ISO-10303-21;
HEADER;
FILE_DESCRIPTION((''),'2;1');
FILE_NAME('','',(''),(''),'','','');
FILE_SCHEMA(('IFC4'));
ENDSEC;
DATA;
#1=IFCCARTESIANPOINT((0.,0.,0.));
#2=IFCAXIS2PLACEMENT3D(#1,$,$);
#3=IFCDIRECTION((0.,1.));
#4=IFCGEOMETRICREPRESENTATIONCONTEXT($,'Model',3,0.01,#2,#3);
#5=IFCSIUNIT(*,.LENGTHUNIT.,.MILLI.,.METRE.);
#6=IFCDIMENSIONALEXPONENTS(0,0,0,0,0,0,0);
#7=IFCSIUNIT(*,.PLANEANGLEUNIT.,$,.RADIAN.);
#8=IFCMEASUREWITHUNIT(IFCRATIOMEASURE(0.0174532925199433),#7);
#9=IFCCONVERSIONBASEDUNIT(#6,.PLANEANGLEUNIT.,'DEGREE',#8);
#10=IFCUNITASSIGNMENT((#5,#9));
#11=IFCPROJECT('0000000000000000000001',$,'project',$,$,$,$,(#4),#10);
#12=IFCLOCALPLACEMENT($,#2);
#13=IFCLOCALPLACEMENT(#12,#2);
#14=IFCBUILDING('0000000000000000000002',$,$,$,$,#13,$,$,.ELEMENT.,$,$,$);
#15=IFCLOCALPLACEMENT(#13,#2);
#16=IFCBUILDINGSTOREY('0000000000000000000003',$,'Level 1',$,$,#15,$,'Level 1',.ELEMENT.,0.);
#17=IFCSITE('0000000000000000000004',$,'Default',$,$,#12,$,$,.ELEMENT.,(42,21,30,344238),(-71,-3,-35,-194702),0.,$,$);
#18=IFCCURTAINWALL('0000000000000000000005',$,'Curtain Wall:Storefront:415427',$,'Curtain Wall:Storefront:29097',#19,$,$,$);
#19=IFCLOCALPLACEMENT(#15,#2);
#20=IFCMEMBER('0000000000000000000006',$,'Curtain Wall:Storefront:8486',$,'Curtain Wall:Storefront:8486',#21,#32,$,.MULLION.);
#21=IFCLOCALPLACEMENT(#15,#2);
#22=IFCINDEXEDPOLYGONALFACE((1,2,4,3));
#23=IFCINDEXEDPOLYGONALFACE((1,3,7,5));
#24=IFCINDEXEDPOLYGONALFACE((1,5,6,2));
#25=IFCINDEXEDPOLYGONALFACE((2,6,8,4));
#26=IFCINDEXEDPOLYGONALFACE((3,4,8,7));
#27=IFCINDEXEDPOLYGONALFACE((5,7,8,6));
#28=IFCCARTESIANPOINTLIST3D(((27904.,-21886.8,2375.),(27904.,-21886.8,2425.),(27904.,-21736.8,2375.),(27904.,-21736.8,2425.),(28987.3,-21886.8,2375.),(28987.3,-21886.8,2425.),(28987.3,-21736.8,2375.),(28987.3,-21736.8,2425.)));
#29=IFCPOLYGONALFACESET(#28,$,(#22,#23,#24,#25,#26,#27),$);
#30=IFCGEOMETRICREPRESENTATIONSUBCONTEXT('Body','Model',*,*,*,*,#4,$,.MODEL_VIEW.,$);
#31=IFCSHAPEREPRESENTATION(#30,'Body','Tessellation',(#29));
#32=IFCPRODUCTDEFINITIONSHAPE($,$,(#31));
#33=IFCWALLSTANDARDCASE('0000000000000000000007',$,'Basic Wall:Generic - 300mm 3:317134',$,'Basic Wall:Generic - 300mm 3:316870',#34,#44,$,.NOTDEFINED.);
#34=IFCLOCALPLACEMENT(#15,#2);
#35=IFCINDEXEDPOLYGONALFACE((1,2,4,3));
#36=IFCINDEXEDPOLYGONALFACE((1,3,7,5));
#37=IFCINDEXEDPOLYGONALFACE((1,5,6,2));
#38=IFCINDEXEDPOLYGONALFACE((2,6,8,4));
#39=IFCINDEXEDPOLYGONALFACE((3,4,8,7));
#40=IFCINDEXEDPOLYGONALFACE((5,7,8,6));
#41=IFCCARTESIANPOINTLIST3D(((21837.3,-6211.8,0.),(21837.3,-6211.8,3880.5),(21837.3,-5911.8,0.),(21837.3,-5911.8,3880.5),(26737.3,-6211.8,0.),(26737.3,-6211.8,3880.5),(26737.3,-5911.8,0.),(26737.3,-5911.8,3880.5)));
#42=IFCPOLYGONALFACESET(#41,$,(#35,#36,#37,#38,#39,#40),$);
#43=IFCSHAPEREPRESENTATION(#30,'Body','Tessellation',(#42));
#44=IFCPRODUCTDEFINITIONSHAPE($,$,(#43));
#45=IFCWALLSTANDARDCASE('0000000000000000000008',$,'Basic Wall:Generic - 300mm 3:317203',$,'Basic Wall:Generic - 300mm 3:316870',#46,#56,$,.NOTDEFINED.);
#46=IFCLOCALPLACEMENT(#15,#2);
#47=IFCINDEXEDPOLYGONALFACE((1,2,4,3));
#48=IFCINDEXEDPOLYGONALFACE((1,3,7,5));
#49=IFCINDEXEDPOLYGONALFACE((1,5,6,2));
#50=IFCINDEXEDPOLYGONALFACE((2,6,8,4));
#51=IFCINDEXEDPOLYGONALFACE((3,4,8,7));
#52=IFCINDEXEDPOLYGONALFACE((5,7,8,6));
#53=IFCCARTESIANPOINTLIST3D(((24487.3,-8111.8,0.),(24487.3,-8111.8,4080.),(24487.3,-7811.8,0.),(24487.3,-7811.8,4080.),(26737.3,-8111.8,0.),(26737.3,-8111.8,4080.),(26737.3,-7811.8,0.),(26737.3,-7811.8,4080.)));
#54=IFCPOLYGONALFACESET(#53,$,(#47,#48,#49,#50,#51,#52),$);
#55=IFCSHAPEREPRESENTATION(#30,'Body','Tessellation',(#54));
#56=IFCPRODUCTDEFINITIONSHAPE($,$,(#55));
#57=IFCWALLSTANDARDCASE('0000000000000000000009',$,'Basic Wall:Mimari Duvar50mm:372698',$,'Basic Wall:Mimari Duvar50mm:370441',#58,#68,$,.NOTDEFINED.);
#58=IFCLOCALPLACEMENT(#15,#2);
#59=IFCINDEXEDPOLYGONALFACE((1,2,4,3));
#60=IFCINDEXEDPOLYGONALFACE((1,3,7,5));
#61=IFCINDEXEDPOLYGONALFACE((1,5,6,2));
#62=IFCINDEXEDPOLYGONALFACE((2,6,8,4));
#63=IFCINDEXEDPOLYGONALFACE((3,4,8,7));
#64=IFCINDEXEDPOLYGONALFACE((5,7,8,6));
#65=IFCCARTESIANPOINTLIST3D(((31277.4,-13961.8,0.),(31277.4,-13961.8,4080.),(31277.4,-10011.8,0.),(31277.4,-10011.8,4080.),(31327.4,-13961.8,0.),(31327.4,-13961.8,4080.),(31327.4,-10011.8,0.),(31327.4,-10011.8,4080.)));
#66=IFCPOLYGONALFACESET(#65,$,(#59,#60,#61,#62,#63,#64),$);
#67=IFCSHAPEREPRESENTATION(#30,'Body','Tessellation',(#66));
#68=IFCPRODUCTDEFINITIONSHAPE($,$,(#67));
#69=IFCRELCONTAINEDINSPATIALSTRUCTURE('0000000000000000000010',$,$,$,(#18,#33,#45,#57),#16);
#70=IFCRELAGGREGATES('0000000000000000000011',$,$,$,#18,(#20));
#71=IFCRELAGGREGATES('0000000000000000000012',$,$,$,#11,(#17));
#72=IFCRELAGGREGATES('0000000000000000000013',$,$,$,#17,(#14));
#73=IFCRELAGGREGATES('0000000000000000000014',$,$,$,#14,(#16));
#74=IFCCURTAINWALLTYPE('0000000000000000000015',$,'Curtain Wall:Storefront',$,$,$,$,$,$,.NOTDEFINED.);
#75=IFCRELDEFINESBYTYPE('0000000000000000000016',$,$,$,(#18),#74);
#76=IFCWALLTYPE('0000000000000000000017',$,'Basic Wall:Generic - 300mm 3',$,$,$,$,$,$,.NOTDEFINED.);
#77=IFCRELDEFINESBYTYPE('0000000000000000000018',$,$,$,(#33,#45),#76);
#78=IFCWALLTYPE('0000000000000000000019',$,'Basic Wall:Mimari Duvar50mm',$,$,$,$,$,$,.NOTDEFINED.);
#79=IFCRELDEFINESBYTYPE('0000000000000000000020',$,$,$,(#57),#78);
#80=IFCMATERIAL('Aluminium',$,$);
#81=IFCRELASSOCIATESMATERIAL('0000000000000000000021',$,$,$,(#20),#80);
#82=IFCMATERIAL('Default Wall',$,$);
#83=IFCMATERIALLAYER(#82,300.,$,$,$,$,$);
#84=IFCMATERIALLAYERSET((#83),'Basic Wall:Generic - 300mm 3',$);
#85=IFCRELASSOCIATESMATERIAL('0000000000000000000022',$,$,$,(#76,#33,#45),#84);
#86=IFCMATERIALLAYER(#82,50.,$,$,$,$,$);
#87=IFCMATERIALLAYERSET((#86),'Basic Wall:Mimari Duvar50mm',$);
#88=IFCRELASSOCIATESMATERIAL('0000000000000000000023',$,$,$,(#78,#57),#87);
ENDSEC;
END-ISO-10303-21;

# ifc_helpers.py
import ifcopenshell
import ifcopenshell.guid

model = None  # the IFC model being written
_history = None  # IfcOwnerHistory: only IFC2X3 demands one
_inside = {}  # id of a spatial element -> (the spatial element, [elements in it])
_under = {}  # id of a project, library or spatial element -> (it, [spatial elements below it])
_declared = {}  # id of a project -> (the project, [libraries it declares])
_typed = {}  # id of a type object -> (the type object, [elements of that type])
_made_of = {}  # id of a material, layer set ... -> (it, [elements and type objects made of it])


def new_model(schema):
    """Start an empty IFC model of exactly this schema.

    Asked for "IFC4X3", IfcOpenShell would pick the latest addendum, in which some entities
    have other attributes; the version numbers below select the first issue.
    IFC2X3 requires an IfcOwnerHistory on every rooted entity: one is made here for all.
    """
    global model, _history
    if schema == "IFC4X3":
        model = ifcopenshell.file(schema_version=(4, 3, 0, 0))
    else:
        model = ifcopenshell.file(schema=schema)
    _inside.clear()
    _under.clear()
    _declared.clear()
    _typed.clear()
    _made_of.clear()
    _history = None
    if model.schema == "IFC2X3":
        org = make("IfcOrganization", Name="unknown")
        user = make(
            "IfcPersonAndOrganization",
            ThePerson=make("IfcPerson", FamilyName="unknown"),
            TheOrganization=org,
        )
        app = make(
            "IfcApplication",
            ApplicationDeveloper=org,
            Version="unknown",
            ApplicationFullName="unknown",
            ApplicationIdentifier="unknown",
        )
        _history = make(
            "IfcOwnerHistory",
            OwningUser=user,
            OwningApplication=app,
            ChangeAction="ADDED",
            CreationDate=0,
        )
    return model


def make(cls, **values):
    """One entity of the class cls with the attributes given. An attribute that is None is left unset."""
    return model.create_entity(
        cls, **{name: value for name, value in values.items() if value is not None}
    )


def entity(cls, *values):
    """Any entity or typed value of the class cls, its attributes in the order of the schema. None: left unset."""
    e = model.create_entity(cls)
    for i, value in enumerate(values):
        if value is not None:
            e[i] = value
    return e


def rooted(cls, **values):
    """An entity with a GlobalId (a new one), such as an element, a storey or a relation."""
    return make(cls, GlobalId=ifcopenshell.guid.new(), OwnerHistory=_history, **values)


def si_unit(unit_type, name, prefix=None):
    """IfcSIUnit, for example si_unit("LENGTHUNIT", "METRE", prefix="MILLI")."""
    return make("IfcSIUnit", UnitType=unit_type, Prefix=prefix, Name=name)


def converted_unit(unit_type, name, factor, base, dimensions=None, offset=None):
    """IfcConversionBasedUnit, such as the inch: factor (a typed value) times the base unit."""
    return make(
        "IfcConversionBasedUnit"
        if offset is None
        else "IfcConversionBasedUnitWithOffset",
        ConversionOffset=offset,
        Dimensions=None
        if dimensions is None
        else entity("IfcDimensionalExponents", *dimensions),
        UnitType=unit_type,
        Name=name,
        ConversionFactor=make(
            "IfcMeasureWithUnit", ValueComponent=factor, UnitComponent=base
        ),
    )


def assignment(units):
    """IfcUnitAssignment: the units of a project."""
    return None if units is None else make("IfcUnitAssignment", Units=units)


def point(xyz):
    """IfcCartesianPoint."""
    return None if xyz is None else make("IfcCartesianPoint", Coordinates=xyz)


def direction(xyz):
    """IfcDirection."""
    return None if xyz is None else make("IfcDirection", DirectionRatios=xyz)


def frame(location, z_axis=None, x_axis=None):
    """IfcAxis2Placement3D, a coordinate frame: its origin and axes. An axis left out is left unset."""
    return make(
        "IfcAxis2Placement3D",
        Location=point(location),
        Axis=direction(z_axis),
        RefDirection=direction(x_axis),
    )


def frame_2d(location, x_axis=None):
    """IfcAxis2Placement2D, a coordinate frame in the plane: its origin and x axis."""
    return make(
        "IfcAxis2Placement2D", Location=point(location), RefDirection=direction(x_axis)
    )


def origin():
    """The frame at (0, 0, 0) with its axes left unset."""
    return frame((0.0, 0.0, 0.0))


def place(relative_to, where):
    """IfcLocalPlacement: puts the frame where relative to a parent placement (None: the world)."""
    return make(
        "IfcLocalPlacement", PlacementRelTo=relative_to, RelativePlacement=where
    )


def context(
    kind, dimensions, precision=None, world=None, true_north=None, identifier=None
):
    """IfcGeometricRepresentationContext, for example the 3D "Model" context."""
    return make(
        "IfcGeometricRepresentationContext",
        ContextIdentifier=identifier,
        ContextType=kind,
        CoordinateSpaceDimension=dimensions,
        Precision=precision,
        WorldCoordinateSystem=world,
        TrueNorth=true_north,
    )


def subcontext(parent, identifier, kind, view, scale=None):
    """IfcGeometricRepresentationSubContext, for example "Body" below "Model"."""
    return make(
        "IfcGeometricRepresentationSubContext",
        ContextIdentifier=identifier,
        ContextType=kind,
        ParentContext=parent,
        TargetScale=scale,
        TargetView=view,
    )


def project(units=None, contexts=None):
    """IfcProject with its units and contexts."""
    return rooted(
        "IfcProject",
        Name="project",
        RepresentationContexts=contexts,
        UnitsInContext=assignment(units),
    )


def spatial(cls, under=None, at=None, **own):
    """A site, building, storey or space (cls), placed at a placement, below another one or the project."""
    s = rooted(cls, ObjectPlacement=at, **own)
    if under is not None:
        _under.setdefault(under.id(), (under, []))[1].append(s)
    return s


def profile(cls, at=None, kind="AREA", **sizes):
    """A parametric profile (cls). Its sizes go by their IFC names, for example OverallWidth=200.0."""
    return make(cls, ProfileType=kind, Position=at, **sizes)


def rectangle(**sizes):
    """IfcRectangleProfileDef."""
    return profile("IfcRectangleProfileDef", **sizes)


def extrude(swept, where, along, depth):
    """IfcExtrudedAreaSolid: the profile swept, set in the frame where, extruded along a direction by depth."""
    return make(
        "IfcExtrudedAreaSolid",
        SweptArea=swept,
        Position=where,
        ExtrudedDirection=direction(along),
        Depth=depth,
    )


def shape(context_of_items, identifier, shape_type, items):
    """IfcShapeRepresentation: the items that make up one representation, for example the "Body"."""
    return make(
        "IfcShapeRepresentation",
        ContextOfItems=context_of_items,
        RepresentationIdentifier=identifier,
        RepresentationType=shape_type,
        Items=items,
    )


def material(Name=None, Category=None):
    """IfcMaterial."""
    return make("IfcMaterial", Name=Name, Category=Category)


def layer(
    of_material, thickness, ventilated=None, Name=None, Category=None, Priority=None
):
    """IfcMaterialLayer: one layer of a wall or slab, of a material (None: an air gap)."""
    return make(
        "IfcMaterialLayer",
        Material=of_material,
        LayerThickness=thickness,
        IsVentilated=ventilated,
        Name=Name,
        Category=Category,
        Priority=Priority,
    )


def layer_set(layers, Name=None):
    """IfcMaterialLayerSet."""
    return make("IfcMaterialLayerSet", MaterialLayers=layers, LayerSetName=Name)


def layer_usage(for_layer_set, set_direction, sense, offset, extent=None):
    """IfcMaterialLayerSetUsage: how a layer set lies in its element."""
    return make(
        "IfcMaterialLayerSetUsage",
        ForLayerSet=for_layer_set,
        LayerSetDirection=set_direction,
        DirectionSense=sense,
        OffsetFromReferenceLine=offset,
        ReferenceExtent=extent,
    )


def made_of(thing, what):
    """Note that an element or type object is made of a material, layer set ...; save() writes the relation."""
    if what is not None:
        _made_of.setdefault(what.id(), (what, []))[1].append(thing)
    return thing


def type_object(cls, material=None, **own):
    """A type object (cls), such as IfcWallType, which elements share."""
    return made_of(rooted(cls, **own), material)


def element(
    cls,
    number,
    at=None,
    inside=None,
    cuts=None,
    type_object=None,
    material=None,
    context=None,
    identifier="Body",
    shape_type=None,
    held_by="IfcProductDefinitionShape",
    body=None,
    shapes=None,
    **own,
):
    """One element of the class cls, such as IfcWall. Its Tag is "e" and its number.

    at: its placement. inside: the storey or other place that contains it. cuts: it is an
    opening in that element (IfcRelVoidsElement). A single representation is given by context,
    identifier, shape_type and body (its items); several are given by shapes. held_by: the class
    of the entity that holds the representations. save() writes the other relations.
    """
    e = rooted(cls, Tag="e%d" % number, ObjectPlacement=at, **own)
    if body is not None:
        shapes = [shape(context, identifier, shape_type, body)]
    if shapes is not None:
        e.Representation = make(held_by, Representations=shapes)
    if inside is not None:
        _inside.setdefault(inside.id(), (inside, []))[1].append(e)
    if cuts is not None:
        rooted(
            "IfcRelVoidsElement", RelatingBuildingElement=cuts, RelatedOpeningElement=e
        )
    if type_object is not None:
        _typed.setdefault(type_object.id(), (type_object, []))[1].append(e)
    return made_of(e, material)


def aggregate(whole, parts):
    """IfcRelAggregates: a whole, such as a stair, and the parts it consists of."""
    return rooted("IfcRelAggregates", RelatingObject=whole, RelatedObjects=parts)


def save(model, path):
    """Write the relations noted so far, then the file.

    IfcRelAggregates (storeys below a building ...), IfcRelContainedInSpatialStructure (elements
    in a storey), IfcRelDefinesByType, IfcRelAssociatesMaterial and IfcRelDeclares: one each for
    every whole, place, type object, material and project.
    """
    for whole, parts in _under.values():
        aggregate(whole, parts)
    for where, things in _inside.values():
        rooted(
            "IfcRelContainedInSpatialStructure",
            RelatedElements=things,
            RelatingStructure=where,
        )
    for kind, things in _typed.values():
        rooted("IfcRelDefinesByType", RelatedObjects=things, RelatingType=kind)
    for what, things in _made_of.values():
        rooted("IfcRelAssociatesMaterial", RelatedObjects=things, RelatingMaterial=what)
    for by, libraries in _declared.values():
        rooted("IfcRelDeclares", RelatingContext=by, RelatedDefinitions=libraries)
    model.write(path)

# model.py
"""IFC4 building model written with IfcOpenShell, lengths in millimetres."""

from ifc_helpers import new_model, entity, si_unit, converted_unit, direction, frame, frame_2d, origin, place, context, subcontext, project, spatial, rectangle, extrude, material, layer, layer_set, layer_usage, type_object, element, aggregate, save


model = new_model("IFC4")

# Units and contexts
model_context = context("Model", 3, precision=0.01, world=origin(), true_north=direction((0.0, 1.0)))
body_context = subcontext(model_context, "Body", "Model", "MODEL_VIEW")
ifc_project = project(units=[si_unit("LENGTHUNIT", "METRE", prefix="MILLI"), converted_unit("PLANEANGLEUNIT", "DEGREE", entity("IfcRatioMeasure", 0.0174532925199433), si_unit("PLANEANGLEUNIT", "RADIAN"), dimensions=[0, 0, 0, 0, 0, 0, 0])], contexts=[model_context])

# Site, building, storey
site_placement = place(None, origin())
site = spatial("IfcSite", under=ifc_project, at=site_placement, Name="Default", CompositionType="ELEMENT", RefLatitude=(42, 21, 30, 344238), RefLongitude=(-71, -3, -35, -194702), RefElevation=0.0)
building_placement = place(site_placement, origin())
building = spatial("IfcBuilding", under=site, at=building_placement, CompositionType="ELEMENT")
storey_placement = place(building_placement, origin())
storey = spatial("IfcBuildingStorey", under=building, at=storey_placement, Name="Level 1", LongName="Level 1", CompositionType="ELEMENT", Elevation=0.0)

# Curtain wall, member
curtain_wall_type = type_object("IfcCurtainWallType", Name="Curtain Wall:Storefront", PredefinedType="NOTDEFINED")
ifc_material_1 = material(Name="Aluminium")
curtain_wall_1_placement = place(storey_placement, origin())
curtain_wall_1 = element("IfcCurtainWall", 1, at=curtain_wall_1_placement, inside=storey, type_object=curtain_wall_type, Name="Curtain Wall:Storefront:415427", ObjectType="Curtain Wall:Storefront:29097")
member_1_placement = place(curtain_wall_1_placement, origin())
member_1 = element("IfcMember", 2, at=member_1_placement, material=ifc_material_1, Name="Curtain Wall:Storefront:8486", ObjectType="Curtain Wall:Storefront:8486", PredefinedType="MULLION", context=body_context, shape_type="SweptSolid", body=[
    extrude(rectangle(XDim=50.0, YDim=150.0, at=frame_2d((0.0, 0.0), x_axis=(1.0, 0.0))), frame((28987.3, -21811.8, 2400.0), z_axis=(-1.0, 0.0, 0.0), x_axis=(0.0, 0.0, -1.0)), (0.0, 0.0, 1.0), 1083.3),
])
aggregate(curtain_wall_1, [member_1])

# Walls
ifc_material_2 = material(Name="Default Wall")
ifc_layer_1 = layer(ifc_material_2, 300.0)
ifc_layer_set_1 = layer_set([ifc_layer_1], Name="Basic Wall:Generic - 300mm 3")
ifc_layer_usage_1 = layer_usage(ifc_layer_set_1, "AXIS2", "NEGATIVE", 150.0)
wall_type_1 = type_object("IfcWallType", Name="Basic Wall:Generic - 300mm 3", PredefinedType="NOTDEFINED", material=ifc_layer_set_1)
wall_1_placement = place(storey_placement, frame((21837.3, -6061.8, 0.0)))
element("IfcWallStandardCase", 3, at=wall_1_placement, inside=storey, type_object=wall_type_1, material=ifc_layer_usage_1, Name="Basic Wall:Generic - 300mm 3:317134", ObjectType="Basic Wall:Generic - 300mm 3:316870", PredefinedType="NOTDEFINED", context=body_context, shape_type="SweptSolid", body=[
    extrude(rectangle(XDim=4900.0, YDim=300.0, at=frame_2d((2450.0, 0.0), x_axis=(-1.0, 0.0))), origin(), (0.0, 0.0, 1.0), 3880.5),
])
ifc_layer_usage_2 = layer_usage(ifc_layer_set_1, "AXIS2", "NEGATIVE", 150.0)
wall_2_placement = place(storey_placement, frame((26737.3, -7961.8, 0.0), z_axis=(0.0, 0.0, 1.0), x_axis=(-1.0, 0.0, 0.0)))
element("IfcWallStandardCase", 4, at=wall_2_placement, inside=storey, type_object=wall_type_1, material=ifc_layer_usage_2, Name="Basic Wall:Generic - 300mm 3:317203", ObjectType="Basic Wall:Generic - 300mm 3:316870", PredefinedType="NOTDEFINED", context=body_context, shape_type="SweptSolid", body=[
    extrude(rectangle(XDim=2250.0, YDim=300.0, at=frame_2d((1125.0, 0.0), x_axis=(-1.0, 0.0))), origin(), (0.0, 0.0, 1.0), 4080.0),
])
ifc_layer_2 = layer(ifc_material_2, 50.0)
ifc_layer_set_2 = layer_set([ifc_layer_2], Name="Basic Wall:Mimari Duvar50mm")
ifc_layer_usage_3 = layer_usage(ifc_layer_set_2, "AXIS2", "NEGATIVE", 25.0)
wall_type_2 = type_object("IfcWallType", Name="Basic Wall:Mimari Duvar50mm", PredefinedType="NOTDEFINED", material=ifc_layer_set_2)
wall_3_placement = place(storey_placement, frame((31302.4, -10011.8, 0.0), z_axis=(0.0, 0.0, 1.0), x_axis=(0.0, -1.0, 0.0)))
element("IfcWallStandardCase", 5, at=wall_3_placement, inside=storey, type_object=wall_type_2, material=ifc_layer_usage_3, Name="Basic Wall:Mimari Duvar50mm:372698", ObjectType="Basic Wall:Mimari Duvar50mm:370441", PredefinedType="NOTDEFINED", context=body_context, shape_type="SweptSolid", body=[
    extrude(rectangle(XDim=3950.0, YDim=50.0, at=frame_2d((1975.0, 0.0), x_axis=(-1.0, 0.0))), origin(), (0.0, 0.0, 1.0), 4080.0),
])

save(model, "model.ifc")
